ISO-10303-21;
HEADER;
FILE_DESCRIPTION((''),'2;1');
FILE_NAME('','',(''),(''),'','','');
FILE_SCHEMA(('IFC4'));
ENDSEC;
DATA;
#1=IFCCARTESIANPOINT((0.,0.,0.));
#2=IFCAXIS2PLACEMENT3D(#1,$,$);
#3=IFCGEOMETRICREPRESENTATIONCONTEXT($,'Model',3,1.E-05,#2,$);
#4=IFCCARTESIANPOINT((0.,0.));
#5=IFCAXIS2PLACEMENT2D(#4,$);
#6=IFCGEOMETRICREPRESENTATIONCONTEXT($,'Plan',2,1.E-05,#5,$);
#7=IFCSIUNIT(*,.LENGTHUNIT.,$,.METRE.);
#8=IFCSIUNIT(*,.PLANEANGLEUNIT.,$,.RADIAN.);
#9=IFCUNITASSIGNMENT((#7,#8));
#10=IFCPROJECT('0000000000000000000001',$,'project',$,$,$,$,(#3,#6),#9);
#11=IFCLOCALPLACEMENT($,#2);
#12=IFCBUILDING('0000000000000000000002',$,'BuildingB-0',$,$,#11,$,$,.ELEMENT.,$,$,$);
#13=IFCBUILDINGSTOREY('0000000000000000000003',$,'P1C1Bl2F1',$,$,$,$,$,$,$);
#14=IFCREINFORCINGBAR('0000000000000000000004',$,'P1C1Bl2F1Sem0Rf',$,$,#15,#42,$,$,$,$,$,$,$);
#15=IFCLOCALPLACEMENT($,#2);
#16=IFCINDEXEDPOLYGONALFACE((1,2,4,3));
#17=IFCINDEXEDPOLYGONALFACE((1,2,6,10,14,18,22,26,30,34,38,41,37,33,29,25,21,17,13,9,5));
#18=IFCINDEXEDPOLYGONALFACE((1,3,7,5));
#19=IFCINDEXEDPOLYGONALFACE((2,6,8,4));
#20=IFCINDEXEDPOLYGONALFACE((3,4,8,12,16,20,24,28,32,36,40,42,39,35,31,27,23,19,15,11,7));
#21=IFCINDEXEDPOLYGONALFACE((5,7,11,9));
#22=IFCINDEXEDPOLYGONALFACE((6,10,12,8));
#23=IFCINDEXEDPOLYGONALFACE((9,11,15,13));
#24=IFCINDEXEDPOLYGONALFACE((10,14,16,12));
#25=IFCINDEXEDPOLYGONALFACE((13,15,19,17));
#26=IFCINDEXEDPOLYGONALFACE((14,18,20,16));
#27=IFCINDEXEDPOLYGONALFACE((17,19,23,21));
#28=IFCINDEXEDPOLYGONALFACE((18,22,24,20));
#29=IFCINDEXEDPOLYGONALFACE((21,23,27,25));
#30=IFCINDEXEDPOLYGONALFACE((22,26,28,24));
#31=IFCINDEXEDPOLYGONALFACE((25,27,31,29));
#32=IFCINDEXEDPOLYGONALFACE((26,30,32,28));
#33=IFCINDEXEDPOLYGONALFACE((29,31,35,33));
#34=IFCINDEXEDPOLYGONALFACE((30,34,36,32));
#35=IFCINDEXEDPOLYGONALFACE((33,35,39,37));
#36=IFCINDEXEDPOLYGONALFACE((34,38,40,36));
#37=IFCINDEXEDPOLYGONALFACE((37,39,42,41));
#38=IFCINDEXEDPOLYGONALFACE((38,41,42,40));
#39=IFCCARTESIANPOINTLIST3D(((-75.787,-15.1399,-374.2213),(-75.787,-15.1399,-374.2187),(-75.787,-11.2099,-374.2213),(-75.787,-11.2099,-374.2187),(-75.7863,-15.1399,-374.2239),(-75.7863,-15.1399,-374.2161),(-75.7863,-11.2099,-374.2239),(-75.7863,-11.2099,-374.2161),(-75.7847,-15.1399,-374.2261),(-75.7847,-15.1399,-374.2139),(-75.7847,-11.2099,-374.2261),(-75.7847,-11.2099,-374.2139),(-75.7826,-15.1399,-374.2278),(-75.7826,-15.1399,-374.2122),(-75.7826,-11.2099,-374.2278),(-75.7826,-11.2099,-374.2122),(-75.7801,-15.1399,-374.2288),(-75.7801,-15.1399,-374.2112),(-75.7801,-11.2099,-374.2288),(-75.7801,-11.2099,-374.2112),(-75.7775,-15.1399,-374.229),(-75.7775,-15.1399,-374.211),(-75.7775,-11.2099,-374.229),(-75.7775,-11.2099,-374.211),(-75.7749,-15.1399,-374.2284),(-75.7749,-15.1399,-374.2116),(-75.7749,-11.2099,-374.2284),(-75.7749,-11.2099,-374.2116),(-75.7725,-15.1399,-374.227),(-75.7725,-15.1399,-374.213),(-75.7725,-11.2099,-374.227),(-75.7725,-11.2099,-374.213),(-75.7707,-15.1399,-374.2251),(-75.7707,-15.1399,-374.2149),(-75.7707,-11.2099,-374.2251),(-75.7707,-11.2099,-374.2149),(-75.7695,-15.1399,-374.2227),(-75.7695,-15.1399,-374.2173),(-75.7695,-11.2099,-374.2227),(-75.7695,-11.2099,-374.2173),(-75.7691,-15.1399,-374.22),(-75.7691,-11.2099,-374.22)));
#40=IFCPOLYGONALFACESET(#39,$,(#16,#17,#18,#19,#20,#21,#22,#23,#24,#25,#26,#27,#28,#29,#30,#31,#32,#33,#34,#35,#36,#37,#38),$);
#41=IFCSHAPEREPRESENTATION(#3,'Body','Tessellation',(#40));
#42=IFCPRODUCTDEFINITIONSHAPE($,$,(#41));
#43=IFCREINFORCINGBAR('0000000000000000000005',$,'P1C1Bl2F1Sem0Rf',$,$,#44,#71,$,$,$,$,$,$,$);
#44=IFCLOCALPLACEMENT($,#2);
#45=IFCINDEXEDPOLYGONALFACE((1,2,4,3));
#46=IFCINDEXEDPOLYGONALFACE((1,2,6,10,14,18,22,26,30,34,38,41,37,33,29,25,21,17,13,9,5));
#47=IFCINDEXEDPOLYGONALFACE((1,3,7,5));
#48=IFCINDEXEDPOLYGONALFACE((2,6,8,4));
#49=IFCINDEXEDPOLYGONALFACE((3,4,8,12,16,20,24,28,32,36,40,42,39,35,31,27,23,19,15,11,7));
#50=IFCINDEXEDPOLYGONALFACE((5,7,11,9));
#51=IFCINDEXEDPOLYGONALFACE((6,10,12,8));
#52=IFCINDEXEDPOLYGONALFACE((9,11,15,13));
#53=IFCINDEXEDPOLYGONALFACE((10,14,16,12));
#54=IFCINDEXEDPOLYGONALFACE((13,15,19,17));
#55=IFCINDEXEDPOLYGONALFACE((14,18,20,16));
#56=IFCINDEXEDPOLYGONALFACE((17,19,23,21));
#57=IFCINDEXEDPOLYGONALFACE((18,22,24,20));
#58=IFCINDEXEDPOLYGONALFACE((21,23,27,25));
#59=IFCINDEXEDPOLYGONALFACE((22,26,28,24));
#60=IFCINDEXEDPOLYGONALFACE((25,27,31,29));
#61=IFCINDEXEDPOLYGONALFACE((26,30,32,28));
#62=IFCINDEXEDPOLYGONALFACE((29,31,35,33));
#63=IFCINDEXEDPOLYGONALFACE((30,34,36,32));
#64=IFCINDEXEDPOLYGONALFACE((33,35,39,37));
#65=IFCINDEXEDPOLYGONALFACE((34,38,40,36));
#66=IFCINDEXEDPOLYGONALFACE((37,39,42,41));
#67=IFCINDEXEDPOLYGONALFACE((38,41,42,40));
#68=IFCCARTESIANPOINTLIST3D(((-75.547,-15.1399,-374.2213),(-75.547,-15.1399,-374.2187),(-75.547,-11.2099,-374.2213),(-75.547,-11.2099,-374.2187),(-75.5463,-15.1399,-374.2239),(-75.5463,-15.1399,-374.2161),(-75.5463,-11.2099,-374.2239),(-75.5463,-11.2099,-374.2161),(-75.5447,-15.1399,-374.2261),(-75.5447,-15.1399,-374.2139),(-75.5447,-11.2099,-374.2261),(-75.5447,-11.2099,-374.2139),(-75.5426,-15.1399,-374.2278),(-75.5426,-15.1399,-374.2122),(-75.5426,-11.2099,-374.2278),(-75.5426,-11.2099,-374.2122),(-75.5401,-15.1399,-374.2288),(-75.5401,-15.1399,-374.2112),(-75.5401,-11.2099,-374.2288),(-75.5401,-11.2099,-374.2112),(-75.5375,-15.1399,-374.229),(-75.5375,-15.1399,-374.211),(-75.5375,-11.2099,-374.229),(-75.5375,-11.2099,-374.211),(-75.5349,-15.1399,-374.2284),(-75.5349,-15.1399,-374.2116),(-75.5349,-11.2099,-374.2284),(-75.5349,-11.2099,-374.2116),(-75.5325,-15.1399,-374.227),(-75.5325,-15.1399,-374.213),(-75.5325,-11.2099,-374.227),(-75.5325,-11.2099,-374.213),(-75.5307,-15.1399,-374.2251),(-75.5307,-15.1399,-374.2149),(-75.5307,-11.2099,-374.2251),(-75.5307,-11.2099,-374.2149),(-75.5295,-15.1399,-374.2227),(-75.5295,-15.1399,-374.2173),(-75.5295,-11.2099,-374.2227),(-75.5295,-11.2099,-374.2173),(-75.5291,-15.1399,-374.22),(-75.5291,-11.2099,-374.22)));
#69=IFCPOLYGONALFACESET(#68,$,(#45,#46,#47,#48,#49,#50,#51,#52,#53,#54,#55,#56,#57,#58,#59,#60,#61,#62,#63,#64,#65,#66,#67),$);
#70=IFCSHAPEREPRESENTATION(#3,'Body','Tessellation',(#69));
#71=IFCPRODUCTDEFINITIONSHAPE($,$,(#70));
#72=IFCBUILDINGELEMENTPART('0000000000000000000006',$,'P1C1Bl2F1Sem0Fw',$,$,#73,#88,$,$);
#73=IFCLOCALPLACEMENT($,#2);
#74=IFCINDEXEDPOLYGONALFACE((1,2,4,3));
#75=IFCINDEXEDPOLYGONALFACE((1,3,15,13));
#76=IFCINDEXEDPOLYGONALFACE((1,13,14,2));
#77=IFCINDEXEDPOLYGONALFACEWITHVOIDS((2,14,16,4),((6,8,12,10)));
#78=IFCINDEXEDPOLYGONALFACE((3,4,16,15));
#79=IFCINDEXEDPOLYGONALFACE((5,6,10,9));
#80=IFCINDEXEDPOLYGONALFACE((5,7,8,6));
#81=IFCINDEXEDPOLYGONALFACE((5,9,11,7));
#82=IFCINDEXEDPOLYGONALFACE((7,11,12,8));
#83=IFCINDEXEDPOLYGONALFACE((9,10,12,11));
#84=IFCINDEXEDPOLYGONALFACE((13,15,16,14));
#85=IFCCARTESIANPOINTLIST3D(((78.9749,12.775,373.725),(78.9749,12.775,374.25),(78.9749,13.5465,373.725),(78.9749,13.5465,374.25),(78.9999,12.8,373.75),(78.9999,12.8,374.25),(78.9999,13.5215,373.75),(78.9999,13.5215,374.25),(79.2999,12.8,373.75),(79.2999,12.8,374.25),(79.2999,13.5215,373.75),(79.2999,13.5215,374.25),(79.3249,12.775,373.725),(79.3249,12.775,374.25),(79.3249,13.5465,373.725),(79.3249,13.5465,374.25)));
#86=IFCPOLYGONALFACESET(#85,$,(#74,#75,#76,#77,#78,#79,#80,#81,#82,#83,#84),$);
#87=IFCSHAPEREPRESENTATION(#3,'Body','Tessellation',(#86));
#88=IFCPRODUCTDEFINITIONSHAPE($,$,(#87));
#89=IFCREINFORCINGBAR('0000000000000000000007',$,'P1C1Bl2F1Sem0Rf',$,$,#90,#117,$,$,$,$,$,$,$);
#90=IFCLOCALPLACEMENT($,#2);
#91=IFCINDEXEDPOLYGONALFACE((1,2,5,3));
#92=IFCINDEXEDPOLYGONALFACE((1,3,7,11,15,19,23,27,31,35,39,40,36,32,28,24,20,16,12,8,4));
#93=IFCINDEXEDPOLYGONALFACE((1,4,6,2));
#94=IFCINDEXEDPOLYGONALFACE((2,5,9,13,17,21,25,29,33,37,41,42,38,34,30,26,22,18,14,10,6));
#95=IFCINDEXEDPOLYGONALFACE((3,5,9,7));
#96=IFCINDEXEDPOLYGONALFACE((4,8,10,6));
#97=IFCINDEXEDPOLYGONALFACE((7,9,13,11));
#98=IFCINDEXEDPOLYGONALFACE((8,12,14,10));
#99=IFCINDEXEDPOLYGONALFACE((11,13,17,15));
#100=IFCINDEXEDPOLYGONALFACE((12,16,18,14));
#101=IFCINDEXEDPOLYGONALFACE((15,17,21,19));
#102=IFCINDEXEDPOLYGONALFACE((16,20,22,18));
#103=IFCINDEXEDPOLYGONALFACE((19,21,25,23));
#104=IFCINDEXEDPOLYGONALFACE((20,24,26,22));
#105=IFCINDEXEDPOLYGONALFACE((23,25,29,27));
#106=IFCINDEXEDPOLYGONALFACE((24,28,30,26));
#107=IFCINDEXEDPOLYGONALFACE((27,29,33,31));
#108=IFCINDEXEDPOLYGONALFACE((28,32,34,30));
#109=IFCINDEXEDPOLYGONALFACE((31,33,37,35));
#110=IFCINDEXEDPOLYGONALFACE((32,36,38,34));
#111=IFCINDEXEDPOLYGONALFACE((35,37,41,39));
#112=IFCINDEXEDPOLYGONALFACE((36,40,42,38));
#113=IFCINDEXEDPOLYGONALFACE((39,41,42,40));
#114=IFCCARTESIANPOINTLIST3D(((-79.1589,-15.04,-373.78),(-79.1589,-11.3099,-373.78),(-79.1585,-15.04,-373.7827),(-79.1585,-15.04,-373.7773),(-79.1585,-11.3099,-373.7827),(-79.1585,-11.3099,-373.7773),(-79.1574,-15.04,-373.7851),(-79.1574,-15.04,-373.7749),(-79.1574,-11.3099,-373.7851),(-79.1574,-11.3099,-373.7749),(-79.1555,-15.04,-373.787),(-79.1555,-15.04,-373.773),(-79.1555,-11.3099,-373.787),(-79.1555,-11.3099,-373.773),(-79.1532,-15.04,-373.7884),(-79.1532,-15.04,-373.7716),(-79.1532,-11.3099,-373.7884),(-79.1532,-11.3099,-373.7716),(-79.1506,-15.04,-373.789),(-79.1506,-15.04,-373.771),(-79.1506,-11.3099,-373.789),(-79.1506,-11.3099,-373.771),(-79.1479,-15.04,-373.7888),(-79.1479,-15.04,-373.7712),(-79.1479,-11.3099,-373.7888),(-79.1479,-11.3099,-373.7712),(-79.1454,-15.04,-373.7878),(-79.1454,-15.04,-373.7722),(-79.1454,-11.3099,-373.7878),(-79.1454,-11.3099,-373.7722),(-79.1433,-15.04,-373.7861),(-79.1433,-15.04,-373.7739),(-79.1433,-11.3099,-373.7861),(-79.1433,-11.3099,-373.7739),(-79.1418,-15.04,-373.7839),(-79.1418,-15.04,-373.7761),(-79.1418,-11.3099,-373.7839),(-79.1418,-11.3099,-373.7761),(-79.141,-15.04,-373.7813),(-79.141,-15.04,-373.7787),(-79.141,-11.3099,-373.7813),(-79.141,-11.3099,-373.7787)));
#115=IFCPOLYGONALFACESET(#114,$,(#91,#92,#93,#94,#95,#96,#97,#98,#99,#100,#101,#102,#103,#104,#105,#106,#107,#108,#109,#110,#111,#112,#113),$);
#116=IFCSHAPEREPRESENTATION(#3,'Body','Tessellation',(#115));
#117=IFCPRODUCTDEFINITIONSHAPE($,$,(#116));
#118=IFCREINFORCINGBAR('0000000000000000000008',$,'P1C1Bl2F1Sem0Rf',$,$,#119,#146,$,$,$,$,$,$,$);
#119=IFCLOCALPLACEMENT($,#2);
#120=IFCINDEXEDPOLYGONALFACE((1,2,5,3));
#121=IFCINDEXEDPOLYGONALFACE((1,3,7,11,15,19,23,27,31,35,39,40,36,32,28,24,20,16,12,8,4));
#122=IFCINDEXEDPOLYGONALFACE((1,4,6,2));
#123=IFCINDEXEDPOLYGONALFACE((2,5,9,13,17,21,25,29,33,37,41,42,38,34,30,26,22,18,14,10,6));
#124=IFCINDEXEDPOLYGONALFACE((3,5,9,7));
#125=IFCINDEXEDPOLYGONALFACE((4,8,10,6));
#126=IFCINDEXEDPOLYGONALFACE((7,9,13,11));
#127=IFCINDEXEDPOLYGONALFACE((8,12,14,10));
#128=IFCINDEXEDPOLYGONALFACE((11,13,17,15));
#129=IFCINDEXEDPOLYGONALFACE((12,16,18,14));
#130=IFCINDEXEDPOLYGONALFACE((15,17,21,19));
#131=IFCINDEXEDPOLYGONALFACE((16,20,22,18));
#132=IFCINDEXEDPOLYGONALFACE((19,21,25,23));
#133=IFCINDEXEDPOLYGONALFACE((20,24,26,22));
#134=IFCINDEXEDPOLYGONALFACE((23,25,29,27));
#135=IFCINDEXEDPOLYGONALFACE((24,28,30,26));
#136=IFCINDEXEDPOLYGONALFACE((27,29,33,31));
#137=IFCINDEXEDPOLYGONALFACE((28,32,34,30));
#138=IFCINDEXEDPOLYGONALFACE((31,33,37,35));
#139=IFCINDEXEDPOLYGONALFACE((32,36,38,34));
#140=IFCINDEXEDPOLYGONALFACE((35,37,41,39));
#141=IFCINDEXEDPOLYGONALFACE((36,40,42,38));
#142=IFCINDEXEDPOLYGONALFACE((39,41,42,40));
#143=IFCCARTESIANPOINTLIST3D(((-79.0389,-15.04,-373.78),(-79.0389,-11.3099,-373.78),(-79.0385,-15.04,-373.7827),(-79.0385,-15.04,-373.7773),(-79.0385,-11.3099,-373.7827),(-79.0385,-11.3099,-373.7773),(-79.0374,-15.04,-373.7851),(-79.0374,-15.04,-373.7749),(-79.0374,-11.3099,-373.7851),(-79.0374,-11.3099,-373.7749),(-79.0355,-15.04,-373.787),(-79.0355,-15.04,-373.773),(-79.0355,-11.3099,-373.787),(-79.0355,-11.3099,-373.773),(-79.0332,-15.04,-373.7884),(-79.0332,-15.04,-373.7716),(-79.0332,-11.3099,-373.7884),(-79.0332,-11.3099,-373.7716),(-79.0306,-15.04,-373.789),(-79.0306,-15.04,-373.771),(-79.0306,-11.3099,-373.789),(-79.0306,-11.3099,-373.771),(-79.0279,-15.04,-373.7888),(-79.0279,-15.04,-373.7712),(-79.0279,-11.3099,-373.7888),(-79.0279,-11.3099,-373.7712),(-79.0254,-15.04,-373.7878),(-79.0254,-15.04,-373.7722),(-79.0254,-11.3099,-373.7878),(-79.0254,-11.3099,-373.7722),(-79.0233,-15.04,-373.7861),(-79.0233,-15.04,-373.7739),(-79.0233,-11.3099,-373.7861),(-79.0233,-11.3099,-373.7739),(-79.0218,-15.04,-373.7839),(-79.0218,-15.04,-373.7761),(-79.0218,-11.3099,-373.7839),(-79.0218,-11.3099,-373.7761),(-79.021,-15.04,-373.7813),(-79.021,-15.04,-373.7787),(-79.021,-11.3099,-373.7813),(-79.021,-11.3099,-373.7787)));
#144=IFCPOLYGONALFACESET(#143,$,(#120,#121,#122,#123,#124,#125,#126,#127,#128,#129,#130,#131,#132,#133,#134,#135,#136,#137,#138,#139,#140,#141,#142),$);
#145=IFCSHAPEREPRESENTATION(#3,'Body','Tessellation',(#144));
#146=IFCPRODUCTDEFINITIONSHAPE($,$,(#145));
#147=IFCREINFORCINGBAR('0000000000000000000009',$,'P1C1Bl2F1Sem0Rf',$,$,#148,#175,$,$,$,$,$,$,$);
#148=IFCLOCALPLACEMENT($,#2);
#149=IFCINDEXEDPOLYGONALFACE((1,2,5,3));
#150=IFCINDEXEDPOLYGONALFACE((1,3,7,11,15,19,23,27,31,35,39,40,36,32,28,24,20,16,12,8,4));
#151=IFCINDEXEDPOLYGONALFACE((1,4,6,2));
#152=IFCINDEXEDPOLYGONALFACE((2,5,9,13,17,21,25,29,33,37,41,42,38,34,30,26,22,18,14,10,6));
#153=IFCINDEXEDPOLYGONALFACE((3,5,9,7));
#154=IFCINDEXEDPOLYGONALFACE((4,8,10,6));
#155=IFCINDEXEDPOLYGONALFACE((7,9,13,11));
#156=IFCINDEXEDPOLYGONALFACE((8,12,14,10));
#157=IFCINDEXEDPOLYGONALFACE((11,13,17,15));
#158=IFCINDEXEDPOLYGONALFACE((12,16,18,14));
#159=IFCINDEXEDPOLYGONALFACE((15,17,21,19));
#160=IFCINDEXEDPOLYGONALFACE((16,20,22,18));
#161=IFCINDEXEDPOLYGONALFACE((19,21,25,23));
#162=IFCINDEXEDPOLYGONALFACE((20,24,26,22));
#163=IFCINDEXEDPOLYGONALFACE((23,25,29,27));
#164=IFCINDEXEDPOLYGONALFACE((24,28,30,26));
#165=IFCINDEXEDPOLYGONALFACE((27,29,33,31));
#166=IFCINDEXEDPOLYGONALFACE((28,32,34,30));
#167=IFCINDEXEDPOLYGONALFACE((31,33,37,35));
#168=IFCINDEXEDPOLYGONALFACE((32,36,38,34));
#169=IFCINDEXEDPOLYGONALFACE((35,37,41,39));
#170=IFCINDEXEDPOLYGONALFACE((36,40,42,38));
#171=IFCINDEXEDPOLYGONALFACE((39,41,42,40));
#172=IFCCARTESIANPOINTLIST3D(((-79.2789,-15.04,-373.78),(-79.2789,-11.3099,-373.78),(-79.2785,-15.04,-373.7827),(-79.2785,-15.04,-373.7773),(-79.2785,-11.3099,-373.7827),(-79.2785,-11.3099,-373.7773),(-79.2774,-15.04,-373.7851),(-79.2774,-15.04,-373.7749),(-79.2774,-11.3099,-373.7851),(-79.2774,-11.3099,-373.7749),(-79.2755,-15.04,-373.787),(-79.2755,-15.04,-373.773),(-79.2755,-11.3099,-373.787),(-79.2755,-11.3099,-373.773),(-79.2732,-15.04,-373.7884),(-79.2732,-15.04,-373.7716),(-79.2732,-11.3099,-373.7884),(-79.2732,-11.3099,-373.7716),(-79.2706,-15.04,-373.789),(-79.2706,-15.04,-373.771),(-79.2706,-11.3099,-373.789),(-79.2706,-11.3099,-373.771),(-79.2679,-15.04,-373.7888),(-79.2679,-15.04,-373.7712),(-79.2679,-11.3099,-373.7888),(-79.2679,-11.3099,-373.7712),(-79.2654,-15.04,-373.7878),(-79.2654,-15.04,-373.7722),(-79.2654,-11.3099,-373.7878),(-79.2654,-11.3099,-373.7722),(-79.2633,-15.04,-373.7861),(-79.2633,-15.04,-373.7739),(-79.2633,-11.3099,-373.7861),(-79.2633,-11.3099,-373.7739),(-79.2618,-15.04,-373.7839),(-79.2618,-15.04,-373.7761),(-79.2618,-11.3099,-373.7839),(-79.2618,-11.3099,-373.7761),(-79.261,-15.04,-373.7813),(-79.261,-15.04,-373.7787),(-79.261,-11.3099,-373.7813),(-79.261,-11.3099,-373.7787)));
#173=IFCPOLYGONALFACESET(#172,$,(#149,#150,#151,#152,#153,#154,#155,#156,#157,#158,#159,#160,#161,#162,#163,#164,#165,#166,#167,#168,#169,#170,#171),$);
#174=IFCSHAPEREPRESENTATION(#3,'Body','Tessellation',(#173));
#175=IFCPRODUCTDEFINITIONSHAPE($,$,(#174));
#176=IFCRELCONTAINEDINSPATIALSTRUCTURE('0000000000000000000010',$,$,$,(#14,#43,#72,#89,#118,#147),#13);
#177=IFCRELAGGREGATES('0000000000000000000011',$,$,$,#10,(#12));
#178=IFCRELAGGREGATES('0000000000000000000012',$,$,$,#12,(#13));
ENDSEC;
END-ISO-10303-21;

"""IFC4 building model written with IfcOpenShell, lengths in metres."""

from ifc_helpers import new_model, entity, si_unit, origin, origin_2d, place, context, project, spatial, polyline, outline, extrude, element, save


model = new_model("IFC4")

# Units and contexts
model_context = context("Model", 3, precision=1e-05, world=origin())
plan_context = context("Plan", 2, precision=1e-05, world=origin_2d())
ifc_project = project(units=[si_unit("LENGTHUNIT", "METRE"), si_unit("PLANEANGLEUNIT", "RADIAN")], contexts=[model_context, plan_context])

# Building, storey
building_placement = place(None, origin())
building = spatial("IfcBuilding", under=ifc_project, at=building_placement, Name="BuildingB-0", CompositionType="ELEMENT")
storey = spatial("IfcBuildingStorey", under=building, Name="P1C1Bl2F1")

# Reinforcing bars
element("IfcReinforcingBar", 1, inside=storey, Name="P1C1Bl2F1Sem0Rf", context=model_context, shape_type="SweptSolid", body=[
    entity("IfcSurfaceCurveSweptAreaSolid", entity("IfcCircleProfileDef", "AREA", None, None, 0.009), None, entity("IfcPolyline", [entity("IfcCartesianPoint", [75.7781, 11.2099, 374.22]), entity("IfcCartesianPoint", [75.7781, 15.1399, 374.22])]), None, None, entity("IfcPlane", entity("IfcAxis2Placement3D", entity("IfcCartesianPoint", [75.7781, 11.2099, 374.22]), entity("IfcDirection", [0.0, 0.0, 1.0]), entity("IfcDirection", [1.0, 0.0, 0.0])))),
])
element("IfcReinforcingBar", 2, inside=storey, Name="P1C1Bl2F1Sem0Rf", context=model_context, shape_type="SweptSolid", body=[
    entity("IfcSurfaceCurveSweptAreaSolid", entity("IfcCircleProfileDef", "AREA", None, None, 0.009), None, entity("IfcPolyline", [entity("IfcCartesianPoint", [75.5381, 11.2099, 374.22]), entity("IfcCartesianPoint", [75.5381, 15.1399, 374.22])]), None, None, entity("IfcPlane", entity("IfcAxis2Placement3D", entity("IfcCartesianPoint", [75.5381, 11.2099, 374.22]), entity("IfcDirection", [0.0, 0.0, 1.0]), entity("IfcDirection", [1.0, 0.0, 0.0])))),
])

# Building element part, opening
building_element_part_1 = element("IfcBuildingElementPart", 3, inside=storey, Name="P1C1Bl2F1Sem0Fw", context=model_context, shape_type="SweptSolid", body=[
    extrude(outline(polyline([(79.3249, 12.775, 373.725), (78.9749, 12.775, 373.725), (78.9749, 13.5465, 373.725), (79.3249, 13.5465, 373.725), (79.3249, 12.775, 373.725)])), None, (0.0, 0.0, 1.0), 0.525),
])
element("IfcOpeningElement", 4, inside=storey, cuts=building_element_part_1, context=model_context, shape_type="SweptSolid", body=[
    extrude(outline(polyline([(79.2999, 12.8, 373.75), (78.9999, 12.8, 373.75), (78.9999, 13.5215, 373.75), (79.2999, 13.5215, 373.75), (79.2999, 12.8, 373.75)])), None, (0.0, 0.0, 1.0), 0.5),
])

# Reinforcing bars
element("IfcReinforcingBar", 5, inside=storey, Name="P1C1Bl2F1Sem0Rf", context=model_context, shape_type="SweptSolid", body=[
    entity("IfcSurfaceCurveSweptAreaSolid", entity("IfcCircleProfileDef", "AREA", None, None, 0.009), None, entity("IfcPolyline", [entity("IfcCartesianPoint", [79.1499, 15.04, 373.78]), entity("IfcCartesianPoint", [79.1499, 11.3099, 373.78])]), None, None, entity("IfcPlane", entity("IfcAxis2Placement3D", entity("IfcCartesianPoint", [79.1499, 15.04, 373.78]), entity("IfcDirection", [0.0, 0.0, 1.0]), entity("IfcDirection", [1.0, 0.0, 0.0])))),
])
element("IfcReinforcingBar", 6, inside=storey, Name="P1C1Bl2F1Sem0Rf", context=model_context, shape_type="SweptSolid", body=[
    entity("IfcSurfaceCurveSweptAreaSolid", entity("IfcCircleProfileDef", "AREA", None, None, 0.009), None, entity("IfcPolyline", [entity("IfcCartesianPoint", [79.0299, 15.04, 373.78]), entity("IfcCartesianPoint", [79.0299, 11.3099, 373.78])]), None, None, entity("IfcPlane", entity("IfcAxis2Placement3D", entity("IfcCartesianPoint", [79.0299, 15.04, 373.78]), entity("IfcDirection", [0.0, 0.0, 1.0]), entity("IfcDirection", [1.0, 0.0, 0.0])))),
])
element("IfcReinforcingBar", 7, inside=storey, Name="P1C1Bl2F1Sem0Rf", context=model_context, shape_type="SweptSolid", body=[
    entity("IfcSurfaceCurveSweptAreaSolid", entity("IfcCircleProfileDef", "AREA", None, None, 0.009), None, entity("IfcPolyline", [entity("IfcCartesianPoint", [79.2699, 15.04, 373.78]), entity("IfcCartesianPoint", [79.2699, 11.3099, 373.78])]), None, None, entity("IfcPlane", entity("IfcAxis2Placement3D", entity("IfcCartesianPoint", [79.2699, 15.04, 373.78]), entity("IfcDirection", [0.0, 0.0, 1.0]), entity("IfcDirection", [1.0, 0.0, 0.0])))),
])

save(model, "model.ifc")
